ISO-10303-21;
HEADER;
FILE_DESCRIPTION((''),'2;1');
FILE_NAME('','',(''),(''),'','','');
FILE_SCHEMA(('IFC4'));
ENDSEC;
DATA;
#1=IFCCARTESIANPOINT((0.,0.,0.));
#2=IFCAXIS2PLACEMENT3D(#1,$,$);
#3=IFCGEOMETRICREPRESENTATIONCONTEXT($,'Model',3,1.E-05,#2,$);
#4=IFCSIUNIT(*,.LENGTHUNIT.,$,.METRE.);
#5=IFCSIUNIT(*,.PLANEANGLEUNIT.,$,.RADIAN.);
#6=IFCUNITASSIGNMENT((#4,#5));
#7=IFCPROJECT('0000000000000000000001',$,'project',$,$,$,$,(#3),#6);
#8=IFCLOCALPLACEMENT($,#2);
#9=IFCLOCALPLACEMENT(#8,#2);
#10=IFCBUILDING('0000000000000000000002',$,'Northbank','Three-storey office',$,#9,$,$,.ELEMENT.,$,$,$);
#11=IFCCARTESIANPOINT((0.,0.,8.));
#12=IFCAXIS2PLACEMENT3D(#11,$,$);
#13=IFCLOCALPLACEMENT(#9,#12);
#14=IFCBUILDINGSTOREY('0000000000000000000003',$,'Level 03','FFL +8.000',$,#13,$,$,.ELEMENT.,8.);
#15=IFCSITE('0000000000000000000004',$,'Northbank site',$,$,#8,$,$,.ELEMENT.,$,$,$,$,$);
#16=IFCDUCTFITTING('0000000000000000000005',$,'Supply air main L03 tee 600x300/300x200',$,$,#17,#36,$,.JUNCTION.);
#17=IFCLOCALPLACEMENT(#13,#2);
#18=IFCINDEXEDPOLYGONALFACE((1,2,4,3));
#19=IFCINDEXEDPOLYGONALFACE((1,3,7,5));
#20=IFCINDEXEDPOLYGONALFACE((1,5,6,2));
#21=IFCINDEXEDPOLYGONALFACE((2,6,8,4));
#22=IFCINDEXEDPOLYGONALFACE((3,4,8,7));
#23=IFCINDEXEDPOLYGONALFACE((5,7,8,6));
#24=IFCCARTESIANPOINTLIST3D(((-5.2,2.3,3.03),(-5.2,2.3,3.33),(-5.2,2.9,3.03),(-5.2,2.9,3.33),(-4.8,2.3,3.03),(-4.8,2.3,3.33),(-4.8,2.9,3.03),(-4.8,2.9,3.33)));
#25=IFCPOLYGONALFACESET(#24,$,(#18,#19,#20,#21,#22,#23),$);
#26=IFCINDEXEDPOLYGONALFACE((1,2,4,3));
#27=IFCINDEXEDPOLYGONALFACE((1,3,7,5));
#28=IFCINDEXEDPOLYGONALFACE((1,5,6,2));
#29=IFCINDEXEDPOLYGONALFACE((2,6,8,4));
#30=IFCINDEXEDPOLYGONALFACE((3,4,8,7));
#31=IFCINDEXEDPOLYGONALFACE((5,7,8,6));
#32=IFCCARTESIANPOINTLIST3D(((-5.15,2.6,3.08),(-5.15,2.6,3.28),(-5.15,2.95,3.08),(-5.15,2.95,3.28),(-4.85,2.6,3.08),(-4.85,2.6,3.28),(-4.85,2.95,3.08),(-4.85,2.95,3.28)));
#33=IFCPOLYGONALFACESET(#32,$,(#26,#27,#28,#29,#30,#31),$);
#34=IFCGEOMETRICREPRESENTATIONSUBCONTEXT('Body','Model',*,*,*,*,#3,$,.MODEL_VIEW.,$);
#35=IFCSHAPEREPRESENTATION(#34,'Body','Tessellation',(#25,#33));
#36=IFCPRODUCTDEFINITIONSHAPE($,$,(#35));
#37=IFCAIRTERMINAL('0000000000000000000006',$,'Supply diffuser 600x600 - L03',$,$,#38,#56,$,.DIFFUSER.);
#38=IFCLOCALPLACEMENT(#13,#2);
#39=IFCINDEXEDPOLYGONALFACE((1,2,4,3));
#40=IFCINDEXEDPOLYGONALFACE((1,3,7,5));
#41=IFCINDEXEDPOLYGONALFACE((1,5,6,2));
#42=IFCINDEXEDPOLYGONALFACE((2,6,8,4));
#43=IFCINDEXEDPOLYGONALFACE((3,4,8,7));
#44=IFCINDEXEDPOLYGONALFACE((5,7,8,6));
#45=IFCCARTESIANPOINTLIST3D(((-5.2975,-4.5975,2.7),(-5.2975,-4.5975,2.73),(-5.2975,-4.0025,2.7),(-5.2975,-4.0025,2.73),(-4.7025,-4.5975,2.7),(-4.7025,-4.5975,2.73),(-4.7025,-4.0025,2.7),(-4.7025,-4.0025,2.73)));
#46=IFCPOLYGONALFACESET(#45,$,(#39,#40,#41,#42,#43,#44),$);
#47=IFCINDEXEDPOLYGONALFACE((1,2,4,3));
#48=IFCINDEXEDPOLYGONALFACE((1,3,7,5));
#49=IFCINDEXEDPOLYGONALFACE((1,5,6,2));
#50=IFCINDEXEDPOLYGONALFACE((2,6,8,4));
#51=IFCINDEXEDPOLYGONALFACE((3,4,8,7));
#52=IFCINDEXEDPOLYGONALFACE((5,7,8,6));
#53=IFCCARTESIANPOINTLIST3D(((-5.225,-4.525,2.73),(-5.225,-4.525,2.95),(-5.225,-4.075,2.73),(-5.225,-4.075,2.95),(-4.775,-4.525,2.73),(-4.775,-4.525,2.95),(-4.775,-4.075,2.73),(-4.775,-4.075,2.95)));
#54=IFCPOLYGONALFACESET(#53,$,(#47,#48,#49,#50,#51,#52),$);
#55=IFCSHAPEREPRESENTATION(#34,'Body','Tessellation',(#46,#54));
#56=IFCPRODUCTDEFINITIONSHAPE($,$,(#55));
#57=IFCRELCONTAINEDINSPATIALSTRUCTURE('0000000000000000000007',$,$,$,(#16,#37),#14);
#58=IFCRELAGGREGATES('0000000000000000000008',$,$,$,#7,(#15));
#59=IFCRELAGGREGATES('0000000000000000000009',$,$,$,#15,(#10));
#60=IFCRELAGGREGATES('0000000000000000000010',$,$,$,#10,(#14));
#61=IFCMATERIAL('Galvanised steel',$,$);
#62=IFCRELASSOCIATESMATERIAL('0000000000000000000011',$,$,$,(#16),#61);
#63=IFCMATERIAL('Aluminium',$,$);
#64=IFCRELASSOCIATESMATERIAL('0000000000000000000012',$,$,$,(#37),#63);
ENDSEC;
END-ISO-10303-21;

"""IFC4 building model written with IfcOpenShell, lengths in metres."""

from ifc_helpers import new_model, si_unit, frame, origin, place, context, subcontext, project, spatial, rectangle, extrude, material, element, save


model = new_model("IFC4")

# Units and contexts
model_context = context("Model", 3, precision=1e-05, world=origin())
body_context = subcontext(model_context, "Body", "Model", "MODEL_VIEW")
ifc_project = project(units=[si_unit("LENGTHUNIT", "METRE"), si_unit("PLANEANGLEUNIT", "RADIAN")], contexts=[model_context])

# Site, building, storey
site_placement = place(None, origin())
site = spatial("IfcSite", under=ifc_project, at=site_placement, Name="Northbank site", CompositionType="ELEMENT")
building_placement = place(site_placement, origin())
building = spatial("IfcBuilding", under=site, at=building_placement, Name="Northbank", Description="Three-storey office", CompositionType="ELEMENT")
storey_placement = place(building_placement, frame((0.0, 0.0, 8.0)))
storey = spatial("IfcBuildingStorey", under=building, at=storey_placement, Name="Level 03", Description="FFL +8.000", CompositionType="ELEMENT", Elevation=8.0)

# Shared definitions
ifc_material_1 = material(Name="Galvanised steel")

# Duct fitting
duct_fitting_1_placement = place(storey_placement, frame((0.0, 0.0, -8.0)))
element("IfcDuctFitting", 1, at=duct_fitting_1_placement, inside=storey, material=ifc_material_1, Name="Supply air main L03 tee 600x300/300x200", PredefinedType="JUNCTION", context=body_context, shape_type="SweptSolid", body=[
    extrude(rectangle(XDim=0.6, YDim=0.3), frame((-4.8, 2.6, 11.18), z_axis=(-1.0, 0.0, 0.0), x_axis=(0.0, -1.0, 0.0)), (0.0, 0.0, 1.0), 0.4),
    extrude(rectangle(XDim=0.3, YDim=0.2), frame((-5.0, 2.6, 11.18), z_axis=(0.0, 1.0, 0.0), x_axis=(-1.0, 0.0, 0.0)), (0.0, 0.0, 1.0), 0.35),
])

# Air terminal
ifc_material_2 = material(Name="Aluminium")
air_terminal_placement = place(storey_placement, frame((0.0, 0.0, -8.0)))
element("IfcAirTerminal", 2, at=air_terminal_placement, inside=storey, material=ifc_material_2, Name="Supply diffuser 600x600 - L03", PredefinedType="DIFFUSER", context=body_context, shape_type="SweptSolid", body=[
    extrude(rectangle(XDim=0.595, YDim=0.595), frame((-5.0, -4.3, 10.7)), (0.0, 0.0, 1.0), 0.03),
    extrude(rectangle(XDim=0.45, YDim=0.45), frame((-5.0, -4.3, 10.73)), (0.0, 0.0, 1.0), 0.22),
])

save(model, "model.ifc")
